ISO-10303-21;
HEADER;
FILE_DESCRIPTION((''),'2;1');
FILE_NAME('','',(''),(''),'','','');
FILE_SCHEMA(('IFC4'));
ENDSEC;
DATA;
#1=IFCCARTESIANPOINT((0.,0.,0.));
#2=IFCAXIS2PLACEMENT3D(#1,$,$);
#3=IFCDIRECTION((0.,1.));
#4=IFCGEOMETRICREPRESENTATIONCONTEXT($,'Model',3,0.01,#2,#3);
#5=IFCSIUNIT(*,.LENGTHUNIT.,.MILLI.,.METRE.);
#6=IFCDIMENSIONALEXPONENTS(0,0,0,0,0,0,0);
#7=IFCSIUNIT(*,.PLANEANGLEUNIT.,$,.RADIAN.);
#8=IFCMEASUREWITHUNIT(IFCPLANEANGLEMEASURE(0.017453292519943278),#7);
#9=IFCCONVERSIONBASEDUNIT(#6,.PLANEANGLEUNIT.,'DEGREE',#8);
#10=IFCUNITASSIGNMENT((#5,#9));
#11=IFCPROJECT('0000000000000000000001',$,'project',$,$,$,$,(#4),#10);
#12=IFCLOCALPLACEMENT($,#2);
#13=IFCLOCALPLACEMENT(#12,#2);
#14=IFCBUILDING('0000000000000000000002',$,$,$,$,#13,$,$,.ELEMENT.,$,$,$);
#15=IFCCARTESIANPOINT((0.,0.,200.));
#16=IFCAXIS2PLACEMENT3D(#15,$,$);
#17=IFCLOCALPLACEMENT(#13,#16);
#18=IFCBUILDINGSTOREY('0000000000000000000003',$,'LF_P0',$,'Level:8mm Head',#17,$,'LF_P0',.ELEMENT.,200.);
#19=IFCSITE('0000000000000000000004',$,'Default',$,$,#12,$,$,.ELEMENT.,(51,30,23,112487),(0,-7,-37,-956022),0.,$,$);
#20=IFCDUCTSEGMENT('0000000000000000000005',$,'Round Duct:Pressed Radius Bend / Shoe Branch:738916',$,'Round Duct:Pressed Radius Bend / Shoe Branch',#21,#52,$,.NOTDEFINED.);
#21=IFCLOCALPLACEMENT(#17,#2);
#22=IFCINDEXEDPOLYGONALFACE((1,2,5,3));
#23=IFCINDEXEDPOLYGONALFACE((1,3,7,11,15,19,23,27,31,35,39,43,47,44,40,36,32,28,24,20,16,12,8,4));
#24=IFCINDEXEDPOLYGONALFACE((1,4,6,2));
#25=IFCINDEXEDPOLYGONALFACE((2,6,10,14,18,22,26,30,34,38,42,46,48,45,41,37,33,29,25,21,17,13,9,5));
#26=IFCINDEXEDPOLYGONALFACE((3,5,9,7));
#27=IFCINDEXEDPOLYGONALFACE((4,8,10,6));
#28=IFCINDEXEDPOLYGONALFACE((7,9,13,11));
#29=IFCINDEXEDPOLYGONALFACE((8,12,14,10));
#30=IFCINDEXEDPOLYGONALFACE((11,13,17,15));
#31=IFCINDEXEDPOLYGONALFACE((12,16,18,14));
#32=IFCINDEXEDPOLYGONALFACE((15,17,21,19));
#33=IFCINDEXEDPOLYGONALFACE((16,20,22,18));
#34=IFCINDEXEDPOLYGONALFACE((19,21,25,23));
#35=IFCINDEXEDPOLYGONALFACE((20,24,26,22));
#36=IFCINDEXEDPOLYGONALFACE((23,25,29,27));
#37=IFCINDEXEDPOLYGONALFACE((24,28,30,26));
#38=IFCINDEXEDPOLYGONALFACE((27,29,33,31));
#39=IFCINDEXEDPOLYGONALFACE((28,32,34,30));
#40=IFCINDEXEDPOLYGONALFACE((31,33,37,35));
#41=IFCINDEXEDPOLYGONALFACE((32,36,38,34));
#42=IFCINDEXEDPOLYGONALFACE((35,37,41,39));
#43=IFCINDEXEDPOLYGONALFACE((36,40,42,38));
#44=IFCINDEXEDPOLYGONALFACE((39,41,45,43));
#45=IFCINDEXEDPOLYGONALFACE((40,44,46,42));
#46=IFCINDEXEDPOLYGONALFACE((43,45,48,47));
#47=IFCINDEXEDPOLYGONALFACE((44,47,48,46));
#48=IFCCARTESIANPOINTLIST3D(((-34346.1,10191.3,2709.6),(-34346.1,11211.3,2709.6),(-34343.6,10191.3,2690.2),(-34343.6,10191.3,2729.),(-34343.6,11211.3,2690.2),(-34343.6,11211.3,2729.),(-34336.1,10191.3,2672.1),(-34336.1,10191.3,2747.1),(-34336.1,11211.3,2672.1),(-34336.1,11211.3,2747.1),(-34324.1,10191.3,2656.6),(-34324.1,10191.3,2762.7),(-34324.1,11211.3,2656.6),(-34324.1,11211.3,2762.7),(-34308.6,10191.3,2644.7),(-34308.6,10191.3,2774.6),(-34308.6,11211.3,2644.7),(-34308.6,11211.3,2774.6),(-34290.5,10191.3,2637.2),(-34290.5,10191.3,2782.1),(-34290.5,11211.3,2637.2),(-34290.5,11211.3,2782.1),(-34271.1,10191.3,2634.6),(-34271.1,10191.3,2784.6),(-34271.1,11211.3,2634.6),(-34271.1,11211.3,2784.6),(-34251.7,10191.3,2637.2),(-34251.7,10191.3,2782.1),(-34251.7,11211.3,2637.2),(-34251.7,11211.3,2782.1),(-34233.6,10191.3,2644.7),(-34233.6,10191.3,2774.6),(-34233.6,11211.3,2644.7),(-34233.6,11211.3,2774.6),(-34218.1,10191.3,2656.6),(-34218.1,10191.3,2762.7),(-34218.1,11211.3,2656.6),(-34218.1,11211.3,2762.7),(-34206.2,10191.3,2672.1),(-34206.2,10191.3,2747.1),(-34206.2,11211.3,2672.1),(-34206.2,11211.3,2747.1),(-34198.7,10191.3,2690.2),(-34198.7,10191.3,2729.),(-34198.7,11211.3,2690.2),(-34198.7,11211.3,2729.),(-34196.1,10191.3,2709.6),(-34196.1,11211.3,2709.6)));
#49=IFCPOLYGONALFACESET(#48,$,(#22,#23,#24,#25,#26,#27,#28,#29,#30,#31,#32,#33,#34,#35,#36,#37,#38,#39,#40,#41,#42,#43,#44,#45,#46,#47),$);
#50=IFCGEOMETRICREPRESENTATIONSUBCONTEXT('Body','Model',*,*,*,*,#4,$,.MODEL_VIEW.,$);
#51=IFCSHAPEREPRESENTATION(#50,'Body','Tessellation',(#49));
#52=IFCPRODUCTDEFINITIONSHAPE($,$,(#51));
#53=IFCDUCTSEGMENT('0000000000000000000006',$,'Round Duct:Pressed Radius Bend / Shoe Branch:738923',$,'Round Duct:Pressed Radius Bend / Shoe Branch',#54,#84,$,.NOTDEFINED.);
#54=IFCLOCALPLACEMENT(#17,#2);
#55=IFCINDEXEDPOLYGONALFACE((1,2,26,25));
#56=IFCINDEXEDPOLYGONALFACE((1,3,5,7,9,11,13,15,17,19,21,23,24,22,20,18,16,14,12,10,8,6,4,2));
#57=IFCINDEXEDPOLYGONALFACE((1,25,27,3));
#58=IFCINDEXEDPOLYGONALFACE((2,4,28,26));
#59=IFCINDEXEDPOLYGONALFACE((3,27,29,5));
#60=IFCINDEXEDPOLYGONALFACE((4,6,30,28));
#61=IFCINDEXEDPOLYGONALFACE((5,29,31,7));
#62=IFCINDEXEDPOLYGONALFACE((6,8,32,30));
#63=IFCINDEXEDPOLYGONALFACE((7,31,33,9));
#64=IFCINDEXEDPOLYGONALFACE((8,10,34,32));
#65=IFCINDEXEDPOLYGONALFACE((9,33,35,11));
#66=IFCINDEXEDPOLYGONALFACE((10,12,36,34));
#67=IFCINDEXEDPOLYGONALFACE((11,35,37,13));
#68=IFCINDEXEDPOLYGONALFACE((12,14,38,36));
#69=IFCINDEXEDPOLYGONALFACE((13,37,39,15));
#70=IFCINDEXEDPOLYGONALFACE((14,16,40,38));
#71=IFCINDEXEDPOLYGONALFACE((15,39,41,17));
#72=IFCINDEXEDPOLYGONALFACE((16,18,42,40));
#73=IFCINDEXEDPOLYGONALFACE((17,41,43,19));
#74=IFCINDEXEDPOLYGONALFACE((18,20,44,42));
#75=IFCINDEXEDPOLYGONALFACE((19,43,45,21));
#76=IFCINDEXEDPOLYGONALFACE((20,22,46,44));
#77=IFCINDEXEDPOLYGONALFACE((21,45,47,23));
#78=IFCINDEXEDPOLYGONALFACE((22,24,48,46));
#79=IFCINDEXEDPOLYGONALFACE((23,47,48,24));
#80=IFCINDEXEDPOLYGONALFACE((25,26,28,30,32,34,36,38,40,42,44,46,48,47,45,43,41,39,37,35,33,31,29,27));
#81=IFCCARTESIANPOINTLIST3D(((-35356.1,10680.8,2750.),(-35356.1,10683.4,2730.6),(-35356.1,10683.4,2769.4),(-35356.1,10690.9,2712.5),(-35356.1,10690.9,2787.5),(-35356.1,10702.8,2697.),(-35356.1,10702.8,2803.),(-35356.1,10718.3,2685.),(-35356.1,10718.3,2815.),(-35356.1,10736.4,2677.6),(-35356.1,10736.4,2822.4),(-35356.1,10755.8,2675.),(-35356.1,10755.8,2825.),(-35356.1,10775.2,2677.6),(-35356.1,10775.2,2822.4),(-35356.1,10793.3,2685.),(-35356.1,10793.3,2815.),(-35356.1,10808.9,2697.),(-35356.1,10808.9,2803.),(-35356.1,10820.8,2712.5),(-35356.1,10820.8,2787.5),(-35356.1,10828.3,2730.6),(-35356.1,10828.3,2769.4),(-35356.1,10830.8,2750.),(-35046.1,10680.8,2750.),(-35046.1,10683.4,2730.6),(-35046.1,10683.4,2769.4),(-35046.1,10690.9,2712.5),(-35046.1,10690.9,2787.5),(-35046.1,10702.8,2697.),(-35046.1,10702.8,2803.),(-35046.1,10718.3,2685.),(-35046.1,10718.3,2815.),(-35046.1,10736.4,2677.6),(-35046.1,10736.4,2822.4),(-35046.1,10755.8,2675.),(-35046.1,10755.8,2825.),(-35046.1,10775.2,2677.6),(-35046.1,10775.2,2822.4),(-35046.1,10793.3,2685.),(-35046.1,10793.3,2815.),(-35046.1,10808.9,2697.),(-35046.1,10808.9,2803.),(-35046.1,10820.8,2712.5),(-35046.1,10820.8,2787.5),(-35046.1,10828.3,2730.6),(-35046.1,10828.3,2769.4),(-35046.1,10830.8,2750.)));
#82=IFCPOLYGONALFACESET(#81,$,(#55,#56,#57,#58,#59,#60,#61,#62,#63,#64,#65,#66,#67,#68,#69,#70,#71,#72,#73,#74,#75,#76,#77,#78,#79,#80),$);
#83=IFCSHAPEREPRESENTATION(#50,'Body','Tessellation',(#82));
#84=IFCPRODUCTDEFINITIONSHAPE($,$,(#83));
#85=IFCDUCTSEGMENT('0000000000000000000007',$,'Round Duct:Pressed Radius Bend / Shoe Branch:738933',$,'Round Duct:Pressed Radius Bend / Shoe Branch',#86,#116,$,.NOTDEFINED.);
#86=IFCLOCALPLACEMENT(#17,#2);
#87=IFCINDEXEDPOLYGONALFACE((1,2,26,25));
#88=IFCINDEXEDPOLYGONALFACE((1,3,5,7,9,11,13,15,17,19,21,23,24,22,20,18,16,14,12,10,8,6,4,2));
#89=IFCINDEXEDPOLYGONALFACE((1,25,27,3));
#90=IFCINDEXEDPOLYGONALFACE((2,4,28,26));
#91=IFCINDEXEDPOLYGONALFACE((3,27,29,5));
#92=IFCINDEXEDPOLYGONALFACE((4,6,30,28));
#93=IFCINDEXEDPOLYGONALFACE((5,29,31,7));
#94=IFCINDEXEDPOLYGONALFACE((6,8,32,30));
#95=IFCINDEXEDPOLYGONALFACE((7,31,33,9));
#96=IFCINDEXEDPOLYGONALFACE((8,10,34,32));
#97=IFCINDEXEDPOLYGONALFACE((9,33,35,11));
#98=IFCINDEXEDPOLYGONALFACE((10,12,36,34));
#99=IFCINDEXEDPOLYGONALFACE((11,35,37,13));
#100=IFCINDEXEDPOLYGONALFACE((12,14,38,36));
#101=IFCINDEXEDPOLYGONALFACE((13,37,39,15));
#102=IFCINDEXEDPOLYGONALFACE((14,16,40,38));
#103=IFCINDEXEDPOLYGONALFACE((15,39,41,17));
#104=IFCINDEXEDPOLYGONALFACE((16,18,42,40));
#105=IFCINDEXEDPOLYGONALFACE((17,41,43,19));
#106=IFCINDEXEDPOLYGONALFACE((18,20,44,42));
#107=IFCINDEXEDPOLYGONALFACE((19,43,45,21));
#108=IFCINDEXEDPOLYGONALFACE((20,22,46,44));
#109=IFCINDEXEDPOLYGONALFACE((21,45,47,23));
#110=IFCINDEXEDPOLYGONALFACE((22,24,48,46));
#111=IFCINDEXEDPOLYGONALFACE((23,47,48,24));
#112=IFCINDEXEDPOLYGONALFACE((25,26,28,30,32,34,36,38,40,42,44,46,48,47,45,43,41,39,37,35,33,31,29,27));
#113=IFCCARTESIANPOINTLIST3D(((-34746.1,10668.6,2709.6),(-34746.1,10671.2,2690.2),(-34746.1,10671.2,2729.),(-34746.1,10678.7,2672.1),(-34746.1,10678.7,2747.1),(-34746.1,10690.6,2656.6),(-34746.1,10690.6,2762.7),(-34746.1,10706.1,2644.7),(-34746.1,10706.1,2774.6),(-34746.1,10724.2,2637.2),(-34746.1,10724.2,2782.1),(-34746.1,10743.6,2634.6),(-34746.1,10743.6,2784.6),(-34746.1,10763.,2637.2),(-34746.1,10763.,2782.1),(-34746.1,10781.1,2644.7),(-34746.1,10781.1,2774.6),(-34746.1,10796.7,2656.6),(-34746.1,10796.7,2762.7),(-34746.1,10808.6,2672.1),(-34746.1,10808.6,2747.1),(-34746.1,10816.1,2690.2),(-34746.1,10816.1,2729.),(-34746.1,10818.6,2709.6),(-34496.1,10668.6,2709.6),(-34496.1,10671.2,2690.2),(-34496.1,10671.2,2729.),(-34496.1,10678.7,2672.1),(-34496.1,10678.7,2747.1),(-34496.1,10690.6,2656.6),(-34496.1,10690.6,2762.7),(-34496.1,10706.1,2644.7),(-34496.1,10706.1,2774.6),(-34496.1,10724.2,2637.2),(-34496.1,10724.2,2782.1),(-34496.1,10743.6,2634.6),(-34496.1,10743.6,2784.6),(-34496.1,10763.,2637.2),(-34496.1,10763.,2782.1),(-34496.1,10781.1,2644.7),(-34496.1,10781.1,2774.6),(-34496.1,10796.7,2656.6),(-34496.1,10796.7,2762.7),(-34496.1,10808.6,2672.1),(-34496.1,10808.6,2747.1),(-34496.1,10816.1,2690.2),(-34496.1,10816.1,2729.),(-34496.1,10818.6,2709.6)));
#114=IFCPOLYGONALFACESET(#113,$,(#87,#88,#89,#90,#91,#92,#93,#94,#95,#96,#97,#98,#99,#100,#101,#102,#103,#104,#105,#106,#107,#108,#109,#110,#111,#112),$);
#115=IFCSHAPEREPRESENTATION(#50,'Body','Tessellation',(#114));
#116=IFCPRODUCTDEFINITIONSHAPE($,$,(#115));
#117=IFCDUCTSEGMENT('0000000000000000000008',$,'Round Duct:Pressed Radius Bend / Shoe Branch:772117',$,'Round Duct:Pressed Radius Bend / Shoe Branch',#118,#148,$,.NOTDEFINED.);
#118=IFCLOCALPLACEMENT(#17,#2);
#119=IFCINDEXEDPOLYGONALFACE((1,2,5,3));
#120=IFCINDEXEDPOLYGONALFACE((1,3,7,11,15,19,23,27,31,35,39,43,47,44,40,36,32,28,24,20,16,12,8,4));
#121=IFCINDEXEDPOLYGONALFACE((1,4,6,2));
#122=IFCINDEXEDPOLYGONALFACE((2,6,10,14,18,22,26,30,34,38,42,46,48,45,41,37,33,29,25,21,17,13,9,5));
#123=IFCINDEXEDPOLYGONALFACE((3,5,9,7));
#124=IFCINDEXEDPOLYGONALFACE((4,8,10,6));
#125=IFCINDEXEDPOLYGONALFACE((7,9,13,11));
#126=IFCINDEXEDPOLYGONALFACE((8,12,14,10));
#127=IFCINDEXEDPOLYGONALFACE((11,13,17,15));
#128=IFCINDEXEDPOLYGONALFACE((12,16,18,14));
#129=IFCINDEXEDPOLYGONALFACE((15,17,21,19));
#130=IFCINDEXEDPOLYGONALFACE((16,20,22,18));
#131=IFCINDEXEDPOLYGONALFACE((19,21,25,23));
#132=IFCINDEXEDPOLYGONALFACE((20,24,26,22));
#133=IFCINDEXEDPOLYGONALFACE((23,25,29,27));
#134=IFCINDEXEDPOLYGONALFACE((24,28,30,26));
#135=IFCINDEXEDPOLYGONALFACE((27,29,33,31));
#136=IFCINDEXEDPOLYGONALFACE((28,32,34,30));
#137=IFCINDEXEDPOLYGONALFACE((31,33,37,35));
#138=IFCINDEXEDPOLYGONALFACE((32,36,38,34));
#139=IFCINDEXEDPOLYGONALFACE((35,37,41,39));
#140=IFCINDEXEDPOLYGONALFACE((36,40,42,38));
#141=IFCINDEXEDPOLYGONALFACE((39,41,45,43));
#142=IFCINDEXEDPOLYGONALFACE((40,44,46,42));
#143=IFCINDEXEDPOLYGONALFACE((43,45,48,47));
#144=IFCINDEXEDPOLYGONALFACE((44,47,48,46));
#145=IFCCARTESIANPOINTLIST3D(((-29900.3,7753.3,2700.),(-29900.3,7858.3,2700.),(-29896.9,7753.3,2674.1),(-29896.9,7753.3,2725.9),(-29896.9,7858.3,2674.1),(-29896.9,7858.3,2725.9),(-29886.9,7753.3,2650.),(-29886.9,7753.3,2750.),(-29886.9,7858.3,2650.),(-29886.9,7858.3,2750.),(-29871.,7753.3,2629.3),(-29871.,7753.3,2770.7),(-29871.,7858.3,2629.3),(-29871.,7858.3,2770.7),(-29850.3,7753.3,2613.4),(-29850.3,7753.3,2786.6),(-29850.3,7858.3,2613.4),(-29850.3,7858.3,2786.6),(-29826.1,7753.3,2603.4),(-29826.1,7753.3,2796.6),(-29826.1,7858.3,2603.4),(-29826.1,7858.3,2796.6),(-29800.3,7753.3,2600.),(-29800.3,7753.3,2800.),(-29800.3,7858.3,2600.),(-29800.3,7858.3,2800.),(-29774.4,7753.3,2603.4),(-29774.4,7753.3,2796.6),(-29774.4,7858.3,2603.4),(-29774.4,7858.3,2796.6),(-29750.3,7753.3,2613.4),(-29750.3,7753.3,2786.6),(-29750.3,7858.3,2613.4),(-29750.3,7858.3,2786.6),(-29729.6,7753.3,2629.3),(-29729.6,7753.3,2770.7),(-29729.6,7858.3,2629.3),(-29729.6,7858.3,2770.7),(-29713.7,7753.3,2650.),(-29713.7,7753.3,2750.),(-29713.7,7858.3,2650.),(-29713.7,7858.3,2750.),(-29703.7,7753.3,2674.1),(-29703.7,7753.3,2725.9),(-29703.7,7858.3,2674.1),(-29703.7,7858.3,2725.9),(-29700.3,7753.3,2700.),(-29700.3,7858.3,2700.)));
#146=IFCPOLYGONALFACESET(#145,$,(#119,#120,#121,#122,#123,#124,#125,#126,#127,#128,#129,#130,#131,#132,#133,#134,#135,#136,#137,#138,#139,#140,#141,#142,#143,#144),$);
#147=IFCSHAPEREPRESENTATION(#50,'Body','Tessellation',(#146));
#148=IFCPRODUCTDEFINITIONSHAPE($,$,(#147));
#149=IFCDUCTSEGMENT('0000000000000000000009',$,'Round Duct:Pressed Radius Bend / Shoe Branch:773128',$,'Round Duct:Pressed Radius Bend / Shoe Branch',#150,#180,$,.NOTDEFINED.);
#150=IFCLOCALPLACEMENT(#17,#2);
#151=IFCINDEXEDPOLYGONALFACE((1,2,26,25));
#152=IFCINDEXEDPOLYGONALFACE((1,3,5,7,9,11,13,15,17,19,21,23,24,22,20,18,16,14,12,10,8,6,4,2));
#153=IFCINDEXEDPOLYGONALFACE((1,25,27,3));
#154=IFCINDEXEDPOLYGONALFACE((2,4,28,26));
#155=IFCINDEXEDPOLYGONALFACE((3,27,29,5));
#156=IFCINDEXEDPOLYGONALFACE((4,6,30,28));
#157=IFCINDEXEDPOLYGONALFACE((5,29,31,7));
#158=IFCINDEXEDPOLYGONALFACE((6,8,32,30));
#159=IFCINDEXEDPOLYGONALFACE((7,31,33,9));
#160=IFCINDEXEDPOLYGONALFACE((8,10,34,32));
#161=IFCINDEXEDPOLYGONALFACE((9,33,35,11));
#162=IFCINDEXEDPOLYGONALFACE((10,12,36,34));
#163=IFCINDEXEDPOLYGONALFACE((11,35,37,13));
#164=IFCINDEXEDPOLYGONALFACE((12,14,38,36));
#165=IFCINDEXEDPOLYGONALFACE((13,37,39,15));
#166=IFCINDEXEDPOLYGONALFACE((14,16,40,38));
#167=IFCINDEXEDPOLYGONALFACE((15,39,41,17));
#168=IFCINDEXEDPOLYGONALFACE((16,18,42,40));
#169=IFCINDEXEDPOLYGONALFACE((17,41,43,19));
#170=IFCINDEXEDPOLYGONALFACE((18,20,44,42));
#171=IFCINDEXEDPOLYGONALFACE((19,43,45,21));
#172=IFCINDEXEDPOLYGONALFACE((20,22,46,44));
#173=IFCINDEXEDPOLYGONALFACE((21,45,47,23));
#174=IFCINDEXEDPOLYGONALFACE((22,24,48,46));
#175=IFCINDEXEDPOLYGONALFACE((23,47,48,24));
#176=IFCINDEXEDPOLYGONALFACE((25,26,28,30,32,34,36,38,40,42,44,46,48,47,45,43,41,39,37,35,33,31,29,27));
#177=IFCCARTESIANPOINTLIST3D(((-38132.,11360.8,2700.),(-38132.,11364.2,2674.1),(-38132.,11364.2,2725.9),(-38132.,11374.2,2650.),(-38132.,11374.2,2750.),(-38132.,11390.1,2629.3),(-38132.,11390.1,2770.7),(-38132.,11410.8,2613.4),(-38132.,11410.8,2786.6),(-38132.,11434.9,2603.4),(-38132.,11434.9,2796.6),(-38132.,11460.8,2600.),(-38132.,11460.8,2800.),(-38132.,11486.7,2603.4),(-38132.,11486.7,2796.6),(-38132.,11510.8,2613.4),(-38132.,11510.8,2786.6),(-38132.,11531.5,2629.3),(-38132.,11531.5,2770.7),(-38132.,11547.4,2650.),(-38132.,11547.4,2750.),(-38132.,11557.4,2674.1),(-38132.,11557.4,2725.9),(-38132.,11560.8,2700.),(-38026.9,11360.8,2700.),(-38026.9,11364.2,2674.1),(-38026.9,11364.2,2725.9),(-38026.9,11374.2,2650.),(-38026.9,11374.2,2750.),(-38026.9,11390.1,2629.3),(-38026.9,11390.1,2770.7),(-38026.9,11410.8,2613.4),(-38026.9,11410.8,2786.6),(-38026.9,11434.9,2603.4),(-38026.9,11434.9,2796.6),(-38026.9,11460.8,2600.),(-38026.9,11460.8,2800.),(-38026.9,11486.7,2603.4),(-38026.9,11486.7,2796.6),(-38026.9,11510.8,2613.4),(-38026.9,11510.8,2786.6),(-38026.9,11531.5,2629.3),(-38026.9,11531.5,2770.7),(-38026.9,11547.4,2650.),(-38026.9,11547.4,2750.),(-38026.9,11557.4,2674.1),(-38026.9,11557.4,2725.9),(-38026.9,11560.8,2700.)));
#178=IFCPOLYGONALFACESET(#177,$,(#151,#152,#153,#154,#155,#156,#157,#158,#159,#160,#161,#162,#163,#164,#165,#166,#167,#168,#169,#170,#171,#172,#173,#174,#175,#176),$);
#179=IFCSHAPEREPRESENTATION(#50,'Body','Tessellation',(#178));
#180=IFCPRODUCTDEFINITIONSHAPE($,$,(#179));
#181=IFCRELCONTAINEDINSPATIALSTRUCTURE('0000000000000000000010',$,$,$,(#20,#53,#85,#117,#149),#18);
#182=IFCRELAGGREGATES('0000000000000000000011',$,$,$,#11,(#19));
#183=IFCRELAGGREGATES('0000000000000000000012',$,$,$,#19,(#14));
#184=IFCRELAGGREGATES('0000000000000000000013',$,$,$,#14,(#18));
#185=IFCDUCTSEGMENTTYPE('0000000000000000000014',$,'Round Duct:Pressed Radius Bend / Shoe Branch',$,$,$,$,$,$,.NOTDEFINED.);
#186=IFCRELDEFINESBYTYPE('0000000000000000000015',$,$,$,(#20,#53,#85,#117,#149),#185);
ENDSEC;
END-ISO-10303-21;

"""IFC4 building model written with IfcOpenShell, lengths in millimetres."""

from ifc_helpers import new_model, entity, si_unit, converted_unit, direction, frame, origin, place, context, subcontext, project, spatial, arc, indexed_curve, outline, extrude, type_object, element, save


model = new_model("IFC4")

# Units and contexts
model_context = context("Model", 3, precision=0.01, world=origin(), true_north=direction((0.0, 1.0)))
body_context = subcontext(model_context, "Body", "Model", "MODEL_VIEW")
ifc_project = project(units=[si_unit("LENGTHUNIT", "METRE", prefix="MILLI"), converted_unit("PLANEANGLEUNIT", "DEGREE", entity("IfcPlaneAngleMeasure", 0.017453292519943278), si_unit("PLANEANGLEUNIT", "RADIAN"), dimensions=[0, 0, 0, 0, 0, 0, 0])], contexts=[model_context])

# Site, building, storey
site_placement = place(None, origin())
site = spatial("IfcSite", under=ifc_project, at=site_placement, Name="Default", CompositionType="ELEMENT", RefLatitude=(51, 30, 23, 112487), RefLongitude=(0, -7, -37, -956022), RefElevation=0.0)
building_placement = place(site_placement, origin())
building = spatial("IfcBuilding", under=site, at=building_placement, CompositionType="ELEMENT")
storey_placement = place(building_placement, frame((0.0, 0.0, 200.0)))
storey = spatial("IfcBuildingStorey", under=building, at=storey_placement, Name="LF_P0", ObjectType="Level:8mm Head", LongName="LF_P0", CompositionType="ELEMENT", Elevation=200.0)

# Duct segments
duct_segment_type_1 = type_object("IfcDuctSegmentType", Name="Round Duct:Pressed Radius Bend / Shoe Branch", PredefinedType="NOTDEFINED")
duct_segment_1_placement = place(storey_placement, origin())
element("IfcDuctSegment", 1, at=duct_segment_1_placement, inside=storey, type_object=duct_segment_type_1, Name="Round Duct:Pressed Radius Bend / Shoe Branch:738916", ObjectType="Round Duct:Pressed Radius Bend / Shoe Branch", PredefinedType="NOTDEFINED", context=body_context, shape_type="SweptSolid", body=[
    extrude(outline(indexed_curve([(75.0, 0.0), (53.0, 53.0), (0.0, 75.0), (-53.0, 53.0), (-75.0, 0.0), (-53.0, -53.0), (0.0, -75.0), (53.0, -53.0)], segments=[arc(1, 2, 3), arc(3, 4, 5), arc(5, 6, 7), arc(7, 8, 1)], self_intersect=False)), frame((-34271.1, 10191.3, 2709.6), z_axis=(0.0, 1.0, 0.0), x_axis=(-1.0, 0.0, 0.0)), (0.0, 0.0, 1.0), 1020.0),
])
duct_segment_2_placement = place(storey_placement, origin())
element("IfcDuctSegment", 2, at=duct_segment_2_placement, inside=storey, type_object=duct_segment_type_1, Name="Round Duct:Pressed Radius Bend / Shoe Branch:738923", ObjectType="Round Duct:Pressed Radius Bend / Shoe Branch", PredefinedType="NOTDEFINED", context=body_context, shape_type="SweptSolid", body=[
    extrude(outline(indexed_curve([(75.0, 0.0), (53.0, 53.0), (0.0, 75.0), (-53.0, 53.0), (-75.0, 0.0), (-53.0, -53.0), (0.0, -75.0), (53.0, -53.0)], segments=[arc(1, 2, 3), arc(3, 4, 5), arc(5, 6, 7), arc(7, 8, 1)], self_intersect=False)), frame((-35356.1, 10755.8, 2750.0), z_axis=(1.0, 0.0, 0.0), x_axis=(0.0, -1.0, 0.0)), (0.0, 0.0, 1.0), 310.0),
])
duct_segment_3_placement = place(storey_placement, origin())
element("IfcDuctSegment", 3, at=duct_segment_3_placement, inside=storey, type_object=duct_segment_type_1, Name="Round Duct:Pressed Radius Bend / Shoe Branch:738933", ObjectType="Round Duct:Pressed Radius Bend / Shoe Branch", PredefinedType="NOTDEFINED", context=body_context, shape_type="SweptSolid", body=[
    extrude(outline(indexed_curve([(75.0, 0.0), (53.0, 53.0), (0.0, 75.0), (-53.0, 53.0), (-75.0, 0.0), (-53.0, -53.0), (0.0, -75.0), (53.0, -53.0)], segments=[arc(1, 2, 3), arc(3, 4, 5), arc(5, 6, 7), arc(7, 8, 1)], self_intersect=False)), frame((-34746.1, 10743.6, 2709.6), z_axis=(1.0, 0.0, 0.0), x_axis=(0.0, 1.0, 0.0)), (0.0, 0.0, 1.0), 250.0),
])
duct_segment_4_placement = place(storey_placement, origin())
element("IfcDuctSegment", 4, at=duct_segment_4_placement, inside=storey, type_object=duct_segment_type_1, Name="Round Duct:Pressed Radius Bend / Shoe Branch:772117", ObjectType="Round Duct:Pressed Radius Bend / Shoe Branch", PredefinedType="NOTDEFINED", context=body_context, shape_type="SweptSolid", body=[
    extrude(outline(indexed_curve([(100.0, 0.0), (70.7, 70.7), (0.0, 100.0), (-70.7, 70.7), (-100.0, 0.0), (-70.7, -70.7), (0.0, -100.0), (70.7, -70.7)], segments=[arc(1, 2, 3), arc(3, 4, 5), arc(5, 6, 7), arc(7, 8, 1)], self_intersect=False)), frame((-29800.3, 7753.3, 2700.0), z_axis=(0.0, 1.0, 0.0), x_axis=(1.0, 0.0, 0.0)), (0.0, 0.0, 1.0), 105.0),
])
duct_segment_5_placement = place(storey_placement, origin())
element("IfcDuctSegment", 5, at=duct_segment_5_placement, inside=storey, type_object=duct_segment_type_1, Name="Round Duct:Pressed Radius Bend / Shoe Branch:773128", ObjectType="Round Duct:Pressed Radius Bend / Shoe Branch", PredefinedType="NOTDEFINED", context=body_context, shape_type="SweptSolid", body=[
    extrude(outline(indexed_curve([(100.0, 0.0), (70.7, 70.7), (0.0, 100.0), (-70.7, 70.7), (-100.0, 0.0), (-70.7, -70.7), (0.0, -100.0), (70.7, -70.7)], segments=[arc(1, 2, 3), arc(3, 4, 5), arc(5, 6, 7), arc(7, 8, 1)], self_intersect=False)), frame((-38132.0, 11460.8, 2700.0), z_axis=(1.0, 0.0, 0.0), x_axis=(0.0, 1.0, 0.0)), (0.0, 0.0, 1.0), 105.0),
])

save(model, "model.ifc")
